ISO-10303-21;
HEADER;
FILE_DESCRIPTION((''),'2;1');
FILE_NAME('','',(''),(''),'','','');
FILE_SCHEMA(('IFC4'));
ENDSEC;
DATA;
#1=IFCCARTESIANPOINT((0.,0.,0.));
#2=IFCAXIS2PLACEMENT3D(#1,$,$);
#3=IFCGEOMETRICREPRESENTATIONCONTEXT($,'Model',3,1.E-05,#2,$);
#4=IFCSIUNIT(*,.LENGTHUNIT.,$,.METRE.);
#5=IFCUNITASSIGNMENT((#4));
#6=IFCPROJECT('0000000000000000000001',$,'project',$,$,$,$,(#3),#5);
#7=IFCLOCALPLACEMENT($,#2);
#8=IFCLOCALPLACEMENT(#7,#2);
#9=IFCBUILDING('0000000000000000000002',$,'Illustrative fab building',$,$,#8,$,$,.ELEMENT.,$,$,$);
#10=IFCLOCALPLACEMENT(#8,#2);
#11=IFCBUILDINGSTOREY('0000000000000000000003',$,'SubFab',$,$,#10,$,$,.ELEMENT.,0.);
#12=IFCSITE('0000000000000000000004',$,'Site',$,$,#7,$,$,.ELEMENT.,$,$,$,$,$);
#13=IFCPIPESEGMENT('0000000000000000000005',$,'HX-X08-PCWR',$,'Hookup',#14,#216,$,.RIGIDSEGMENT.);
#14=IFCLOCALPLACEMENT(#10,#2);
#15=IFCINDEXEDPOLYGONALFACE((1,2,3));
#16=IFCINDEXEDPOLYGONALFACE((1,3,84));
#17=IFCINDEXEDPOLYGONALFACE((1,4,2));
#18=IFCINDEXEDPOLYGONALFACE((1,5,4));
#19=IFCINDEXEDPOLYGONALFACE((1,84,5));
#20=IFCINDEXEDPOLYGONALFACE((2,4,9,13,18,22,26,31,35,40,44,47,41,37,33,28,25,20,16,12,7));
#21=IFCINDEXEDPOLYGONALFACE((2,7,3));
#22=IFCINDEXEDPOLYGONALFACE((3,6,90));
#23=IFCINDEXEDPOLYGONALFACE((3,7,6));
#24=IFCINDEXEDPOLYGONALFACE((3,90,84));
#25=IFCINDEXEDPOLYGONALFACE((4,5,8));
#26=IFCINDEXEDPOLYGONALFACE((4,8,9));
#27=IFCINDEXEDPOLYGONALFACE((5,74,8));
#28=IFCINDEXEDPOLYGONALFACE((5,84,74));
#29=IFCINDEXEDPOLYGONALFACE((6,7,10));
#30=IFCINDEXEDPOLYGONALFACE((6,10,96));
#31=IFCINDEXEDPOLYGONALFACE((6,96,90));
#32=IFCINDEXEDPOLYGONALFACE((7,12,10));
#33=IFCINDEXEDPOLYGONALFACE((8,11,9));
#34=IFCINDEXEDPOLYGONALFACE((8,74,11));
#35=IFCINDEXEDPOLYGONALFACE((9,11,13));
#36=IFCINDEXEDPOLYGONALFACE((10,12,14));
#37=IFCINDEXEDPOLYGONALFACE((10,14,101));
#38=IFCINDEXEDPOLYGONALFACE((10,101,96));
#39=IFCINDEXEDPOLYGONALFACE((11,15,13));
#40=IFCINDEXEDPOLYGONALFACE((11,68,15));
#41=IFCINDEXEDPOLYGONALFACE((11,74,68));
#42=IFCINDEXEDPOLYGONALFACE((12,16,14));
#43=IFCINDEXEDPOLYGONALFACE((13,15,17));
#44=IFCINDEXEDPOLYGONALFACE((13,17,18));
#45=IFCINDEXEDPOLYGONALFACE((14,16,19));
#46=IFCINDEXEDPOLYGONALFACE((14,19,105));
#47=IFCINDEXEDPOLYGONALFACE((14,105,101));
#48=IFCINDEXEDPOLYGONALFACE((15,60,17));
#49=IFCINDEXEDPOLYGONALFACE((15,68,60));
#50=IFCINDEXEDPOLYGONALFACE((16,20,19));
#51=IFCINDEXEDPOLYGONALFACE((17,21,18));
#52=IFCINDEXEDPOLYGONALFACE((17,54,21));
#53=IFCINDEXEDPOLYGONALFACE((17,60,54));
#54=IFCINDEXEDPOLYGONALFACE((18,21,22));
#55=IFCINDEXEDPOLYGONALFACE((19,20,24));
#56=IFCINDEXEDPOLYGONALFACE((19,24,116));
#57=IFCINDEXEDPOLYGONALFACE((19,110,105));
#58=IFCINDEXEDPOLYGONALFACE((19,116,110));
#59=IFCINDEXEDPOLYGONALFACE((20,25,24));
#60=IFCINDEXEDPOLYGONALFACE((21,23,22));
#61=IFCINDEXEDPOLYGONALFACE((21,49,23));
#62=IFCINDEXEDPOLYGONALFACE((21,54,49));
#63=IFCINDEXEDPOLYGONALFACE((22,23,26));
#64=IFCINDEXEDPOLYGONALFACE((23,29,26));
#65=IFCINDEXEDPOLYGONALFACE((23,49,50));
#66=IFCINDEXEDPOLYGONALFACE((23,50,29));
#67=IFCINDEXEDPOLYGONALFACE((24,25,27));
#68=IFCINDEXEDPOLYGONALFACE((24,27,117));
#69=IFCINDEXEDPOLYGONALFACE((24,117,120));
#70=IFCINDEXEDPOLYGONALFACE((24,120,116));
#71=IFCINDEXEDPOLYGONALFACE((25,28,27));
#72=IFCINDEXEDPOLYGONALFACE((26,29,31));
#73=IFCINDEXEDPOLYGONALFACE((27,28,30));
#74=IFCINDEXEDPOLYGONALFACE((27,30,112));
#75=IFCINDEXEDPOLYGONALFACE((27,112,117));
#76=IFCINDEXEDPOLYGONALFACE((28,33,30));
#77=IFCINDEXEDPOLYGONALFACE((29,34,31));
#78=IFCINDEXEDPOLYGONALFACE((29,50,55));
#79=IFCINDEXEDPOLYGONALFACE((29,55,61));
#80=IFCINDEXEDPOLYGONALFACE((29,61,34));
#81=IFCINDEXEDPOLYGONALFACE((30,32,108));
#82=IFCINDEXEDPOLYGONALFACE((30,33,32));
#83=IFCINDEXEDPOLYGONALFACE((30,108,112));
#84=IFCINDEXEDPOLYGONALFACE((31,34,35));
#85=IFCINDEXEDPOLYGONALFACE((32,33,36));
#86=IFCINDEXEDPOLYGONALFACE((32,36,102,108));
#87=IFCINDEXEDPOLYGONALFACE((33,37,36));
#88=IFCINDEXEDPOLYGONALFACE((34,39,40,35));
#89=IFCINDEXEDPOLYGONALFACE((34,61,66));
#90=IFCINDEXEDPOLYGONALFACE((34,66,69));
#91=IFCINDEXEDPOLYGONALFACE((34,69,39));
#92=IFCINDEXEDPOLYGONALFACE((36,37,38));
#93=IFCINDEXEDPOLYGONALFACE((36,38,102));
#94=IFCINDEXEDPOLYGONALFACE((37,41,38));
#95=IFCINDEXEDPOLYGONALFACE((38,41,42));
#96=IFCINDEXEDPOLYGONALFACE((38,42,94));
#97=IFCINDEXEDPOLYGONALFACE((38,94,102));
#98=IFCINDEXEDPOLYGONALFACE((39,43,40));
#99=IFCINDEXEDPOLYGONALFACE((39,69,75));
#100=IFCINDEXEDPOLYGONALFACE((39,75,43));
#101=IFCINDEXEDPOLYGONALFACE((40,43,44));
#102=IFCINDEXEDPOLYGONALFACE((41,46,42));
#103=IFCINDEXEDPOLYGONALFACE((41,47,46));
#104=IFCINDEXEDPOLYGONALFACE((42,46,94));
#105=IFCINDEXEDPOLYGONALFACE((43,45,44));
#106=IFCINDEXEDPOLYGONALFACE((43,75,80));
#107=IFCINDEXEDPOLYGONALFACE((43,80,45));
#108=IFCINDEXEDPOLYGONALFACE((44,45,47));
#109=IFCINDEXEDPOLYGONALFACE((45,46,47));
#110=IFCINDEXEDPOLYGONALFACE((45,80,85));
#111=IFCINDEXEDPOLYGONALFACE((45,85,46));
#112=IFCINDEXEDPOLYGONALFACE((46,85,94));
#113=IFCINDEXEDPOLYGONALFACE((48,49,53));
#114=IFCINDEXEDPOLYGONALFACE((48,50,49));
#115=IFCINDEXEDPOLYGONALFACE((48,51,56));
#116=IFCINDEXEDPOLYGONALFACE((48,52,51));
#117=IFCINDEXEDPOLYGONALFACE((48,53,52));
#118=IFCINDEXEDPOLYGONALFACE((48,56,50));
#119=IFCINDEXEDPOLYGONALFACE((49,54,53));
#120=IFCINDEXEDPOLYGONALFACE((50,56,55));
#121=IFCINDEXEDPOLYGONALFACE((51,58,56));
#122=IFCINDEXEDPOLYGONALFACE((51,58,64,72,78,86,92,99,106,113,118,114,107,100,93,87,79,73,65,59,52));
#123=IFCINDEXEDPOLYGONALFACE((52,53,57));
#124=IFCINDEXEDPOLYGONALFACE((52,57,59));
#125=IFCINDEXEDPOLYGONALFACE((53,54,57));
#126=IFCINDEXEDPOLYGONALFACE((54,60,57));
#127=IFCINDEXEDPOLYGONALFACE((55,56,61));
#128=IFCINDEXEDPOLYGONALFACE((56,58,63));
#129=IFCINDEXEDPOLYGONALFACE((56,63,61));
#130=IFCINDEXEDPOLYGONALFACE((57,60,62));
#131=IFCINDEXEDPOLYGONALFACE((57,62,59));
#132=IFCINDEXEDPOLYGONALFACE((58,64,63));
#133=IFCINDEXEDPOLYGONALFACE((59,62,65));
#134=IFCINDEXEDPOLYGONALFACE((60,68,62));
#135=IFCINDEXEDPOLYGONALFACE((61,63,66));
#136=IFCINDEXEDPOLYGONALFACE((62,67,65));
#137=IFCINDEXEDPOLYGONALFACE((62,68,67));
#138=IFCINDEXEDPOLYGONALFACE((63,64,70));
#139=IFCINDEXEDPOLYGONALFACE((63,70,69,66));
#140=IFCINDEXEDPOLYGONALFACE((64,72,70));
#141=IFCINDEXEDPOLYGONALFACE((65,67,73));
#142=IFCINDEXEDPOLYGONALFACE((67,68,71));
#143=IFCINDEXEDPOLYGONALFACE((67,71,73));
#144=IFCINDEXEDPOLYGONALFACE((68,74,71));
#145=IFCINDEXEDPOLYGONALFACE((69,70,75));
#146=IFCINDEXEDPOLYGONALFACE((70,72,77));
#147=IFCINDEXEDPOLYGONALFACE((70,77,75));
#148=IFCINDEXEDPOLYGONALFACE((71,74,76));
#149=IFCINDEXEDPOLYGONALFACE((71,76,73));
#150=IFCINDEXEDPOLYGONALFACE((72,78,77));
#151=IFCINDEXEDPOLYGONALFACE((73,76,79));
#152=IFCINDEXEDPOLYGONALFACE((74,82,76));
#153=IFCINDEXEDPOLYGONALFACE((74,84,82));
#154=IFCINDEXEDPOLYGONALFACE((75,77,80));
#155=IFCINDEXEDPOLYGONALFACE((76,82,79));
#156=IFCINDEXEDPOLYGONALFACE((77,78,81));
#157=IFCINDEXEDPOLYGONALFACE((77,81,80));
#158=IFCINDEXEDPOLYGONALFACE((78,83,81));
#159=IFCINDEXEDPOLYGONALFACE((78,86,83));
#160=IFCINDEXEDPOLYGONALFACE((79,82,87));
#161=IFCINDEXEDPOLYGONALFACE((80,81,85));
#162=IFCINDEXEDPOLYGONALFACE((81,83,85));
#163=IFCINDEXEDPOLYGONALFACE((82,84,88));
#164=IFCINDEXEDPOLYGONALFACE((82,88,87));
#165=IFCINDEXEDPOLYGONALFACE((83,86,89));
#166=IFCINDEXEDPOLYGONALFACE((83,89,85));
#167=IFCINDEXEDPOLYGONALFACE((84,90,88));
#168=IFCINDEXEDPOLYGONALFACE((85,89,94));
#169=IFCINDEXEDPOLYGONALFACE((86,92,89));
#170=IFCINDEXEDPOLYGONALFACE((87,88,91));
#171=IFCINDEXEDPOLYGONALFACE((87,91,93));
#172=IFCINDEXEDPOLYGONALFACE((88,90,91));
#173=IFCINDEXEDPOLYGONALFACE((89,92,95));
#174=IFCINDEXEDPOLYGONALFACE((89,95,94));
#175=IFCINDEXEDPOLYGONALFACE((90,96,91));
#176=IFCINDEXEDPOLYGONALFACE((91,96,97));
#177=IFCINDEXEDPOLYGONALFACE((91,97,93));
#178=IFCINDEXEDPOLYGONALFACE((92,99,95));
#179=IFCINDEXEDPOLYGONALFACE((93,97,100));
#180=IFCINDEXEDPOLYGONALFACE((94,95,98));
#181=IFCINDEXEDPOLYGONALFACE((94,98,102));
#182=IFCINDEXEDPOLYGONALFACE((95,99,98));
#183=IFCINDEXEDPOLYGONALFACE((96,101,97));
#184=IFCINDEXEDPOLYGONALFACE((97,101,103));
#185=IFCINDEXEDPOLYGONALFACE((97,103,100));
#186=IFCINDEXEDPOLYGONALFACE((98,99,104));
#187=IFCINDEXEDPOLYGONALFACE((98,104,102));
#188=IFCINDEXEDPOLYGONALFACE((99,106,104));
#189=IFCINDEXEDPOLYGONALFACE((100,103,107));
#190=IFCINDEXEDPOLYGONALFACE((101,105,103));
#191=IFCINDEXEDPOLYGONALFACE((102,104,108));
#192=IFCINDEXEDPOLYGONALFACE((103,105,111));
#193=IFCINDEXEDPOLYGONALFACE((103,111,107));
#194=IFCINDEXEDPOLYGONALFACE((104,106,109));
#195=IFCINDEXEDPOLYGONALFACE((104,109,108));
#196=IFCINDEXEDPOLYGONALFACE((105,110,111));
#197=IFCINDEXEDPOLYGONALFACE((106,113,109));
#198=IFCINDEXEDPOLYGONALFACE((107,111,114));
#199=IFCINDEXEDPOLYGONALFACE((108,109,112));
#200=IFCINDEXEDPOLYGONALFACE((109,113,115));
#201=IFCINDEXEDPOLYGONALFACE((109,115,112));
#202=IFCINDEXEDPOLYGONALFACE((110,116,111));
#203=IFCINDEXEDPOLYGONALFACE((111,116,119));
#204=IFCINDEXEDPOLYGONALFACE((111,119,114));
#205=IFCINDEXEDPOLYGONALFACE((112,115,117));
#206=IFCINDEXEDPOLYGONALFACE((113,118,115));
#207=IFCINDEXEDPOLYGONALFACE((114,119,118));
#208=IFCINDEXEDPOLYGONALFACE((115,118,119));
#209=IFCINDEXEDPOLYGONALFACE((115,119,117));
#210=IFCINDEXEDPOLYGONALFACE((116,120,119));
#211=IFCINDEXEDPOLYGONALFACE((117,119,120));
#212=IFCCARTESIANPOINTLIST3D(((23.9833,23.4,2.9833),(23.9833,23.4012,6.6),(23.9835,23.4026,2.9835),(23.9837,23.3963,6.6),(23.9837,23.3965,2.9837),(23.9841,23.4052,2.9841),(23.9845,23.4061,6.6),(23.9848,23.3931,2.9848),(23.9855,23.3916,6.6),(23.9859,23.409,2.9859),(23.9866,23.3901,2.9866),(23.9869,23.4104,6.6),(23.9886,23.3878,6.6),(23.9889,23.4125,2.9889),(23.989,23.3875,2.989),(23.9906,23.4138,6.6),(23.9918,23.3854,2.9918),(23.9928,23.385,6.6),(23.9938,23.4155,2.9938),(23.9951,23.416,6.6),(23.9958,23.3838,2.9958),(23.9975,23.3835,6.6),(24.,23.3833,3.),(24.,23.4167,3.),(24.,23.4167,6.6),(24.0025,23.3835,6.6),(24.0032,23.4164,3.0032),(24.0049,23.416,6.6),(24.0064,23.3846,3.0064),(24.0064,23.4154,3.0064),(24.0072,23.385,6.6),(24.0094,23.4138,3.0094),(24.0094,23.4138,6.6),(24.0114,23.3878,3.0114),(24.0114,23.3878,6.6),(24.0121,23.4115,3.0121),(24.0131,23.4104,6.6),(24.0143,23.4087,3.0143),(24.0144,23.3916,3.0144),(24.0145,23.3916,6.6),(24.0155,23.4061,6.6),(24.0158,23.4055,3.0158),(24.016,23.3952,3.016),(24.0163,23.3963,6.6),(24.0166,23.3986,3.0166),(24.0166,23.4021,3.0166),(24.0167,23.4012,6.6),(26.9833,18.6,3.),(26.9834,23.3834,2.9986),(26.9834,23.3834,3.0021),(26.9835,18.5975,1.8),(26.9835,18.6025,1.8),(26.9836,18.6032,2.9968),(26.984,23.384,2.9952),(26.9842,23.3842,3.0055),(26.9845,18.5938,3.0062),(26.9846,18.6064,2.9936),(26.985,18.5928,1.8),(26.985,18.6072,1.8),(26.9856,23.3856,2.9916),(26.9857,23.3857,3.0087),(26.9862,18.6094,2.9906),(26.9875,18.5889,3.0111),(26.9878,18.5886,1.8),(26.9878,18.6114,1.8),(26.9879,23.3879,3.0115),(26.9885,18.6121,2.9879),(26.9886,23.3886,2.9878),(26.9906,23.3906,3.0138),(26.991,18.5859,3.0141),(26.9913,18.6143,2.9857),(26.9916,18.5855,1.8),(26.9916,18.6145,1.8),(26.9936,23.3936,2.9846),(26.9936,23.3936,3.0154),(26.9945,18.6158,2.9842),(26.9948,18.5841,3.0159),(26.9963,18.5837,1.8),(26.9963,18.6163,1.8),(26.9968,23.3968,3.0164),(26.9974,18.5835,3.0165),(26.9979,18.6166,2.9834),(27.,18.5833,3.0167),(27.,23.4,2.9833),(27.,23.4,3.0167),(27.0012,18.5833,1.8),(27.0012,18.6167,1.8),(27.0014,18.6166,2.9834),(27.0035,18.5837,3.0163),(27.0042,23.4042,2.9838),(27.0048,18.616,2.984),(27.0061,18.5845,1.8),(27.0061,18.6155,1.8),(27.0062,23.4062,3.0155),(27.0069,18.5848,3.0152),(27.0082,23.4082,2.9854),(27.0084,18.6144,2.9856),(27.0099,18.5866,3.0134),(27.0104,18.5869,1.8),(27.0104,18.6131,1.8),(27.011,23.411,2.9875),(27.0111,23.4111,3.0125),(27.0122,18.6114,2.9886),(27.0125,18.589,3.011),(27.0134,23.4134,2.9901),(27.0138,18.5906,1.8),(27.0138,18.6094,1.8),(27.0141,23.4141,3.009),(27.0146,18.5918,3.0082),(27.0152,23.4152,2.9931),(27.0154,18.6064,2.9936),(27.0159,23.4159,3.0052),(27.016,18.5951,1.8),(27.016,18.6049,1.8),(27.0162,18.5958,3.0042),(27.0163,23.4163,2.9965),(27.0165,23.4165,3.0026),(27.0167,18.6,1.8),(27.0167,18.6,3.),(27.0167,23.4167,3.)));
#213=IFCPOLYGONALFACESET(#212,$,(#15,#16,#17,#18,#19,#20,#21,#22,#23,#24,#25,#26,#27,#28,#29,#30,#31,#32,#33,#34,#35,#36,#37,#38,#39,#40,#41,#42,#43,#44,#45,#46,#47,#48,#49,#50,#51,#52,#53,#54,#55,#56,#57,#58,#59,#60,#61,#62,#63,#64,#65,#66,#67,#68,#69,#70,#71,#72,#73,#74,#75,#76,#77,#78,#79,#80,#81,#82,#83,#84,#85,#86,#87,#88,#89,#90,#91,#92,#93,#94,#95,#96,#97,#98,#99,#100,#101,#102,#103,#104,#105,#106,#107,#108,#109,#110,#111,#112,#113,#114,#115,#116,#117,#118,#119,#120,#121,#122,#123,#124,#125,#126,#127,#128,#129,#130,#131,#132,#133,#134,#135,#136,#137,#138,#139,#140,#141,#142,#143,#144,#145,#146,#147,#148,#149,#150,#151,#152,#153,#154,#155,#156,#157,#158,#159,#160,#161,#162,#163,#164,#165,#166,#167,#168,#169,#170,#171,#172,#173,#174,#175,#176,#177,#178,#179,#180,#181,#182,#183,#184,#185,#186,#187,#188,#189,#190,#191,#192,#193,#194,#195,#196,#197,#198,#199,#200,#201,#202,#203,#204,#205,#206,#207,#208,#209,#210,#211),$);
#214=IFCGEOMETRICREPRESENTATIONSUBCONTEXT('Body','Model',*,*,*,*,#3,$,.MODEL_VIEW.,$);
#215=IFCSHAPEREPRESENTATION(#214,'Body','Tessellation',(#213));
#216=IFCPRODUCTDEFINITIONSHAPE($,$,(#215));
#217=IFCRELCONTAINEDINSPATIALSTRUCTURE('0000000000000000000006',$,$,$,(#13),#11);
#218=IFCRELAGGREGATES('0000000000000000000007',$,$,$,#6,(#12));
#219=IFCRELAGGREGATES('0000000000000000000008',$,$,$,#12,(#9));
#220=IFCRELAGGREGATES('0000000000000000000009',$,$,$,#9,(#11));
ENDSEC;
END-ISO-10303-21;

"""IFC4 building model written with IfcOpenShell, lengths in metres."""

from ifc_helpers import new_model, entity, si_unit, origin, place, context, subcontext, project, spatial, element, save


model = new_model("IFC4")

# Units and contexts
model_context = context("Model", 3, precision=1e-05, world=origin())
body_context = subcontext(model_context, "Body", "Model", "MODEL_VIEW")
ifc_project = project(units=[si_unit("LENGTHUNIT", "METRE")], contexts=[model_context])

# Site, building, storey
site_placement = place(None, origin())
site = spatial("IfcSite", under=ifc_project, at=site_placement, Name="Site", CompositionType="ELEMENT")
building_placement = place(site_placement, origin())
building = spatial("IfcBuilding", under=site, at=building_placement, Name="Illustrative fab building", CompositionType="ELEMENT")
storey_placement = place(building_placement, origin())
storey = spatial("IfcBuildingStorey", under=building, at=storey_placement, Name="SubFab", CompositionType="ELEMENT", Elevation=0.0)

# Pipe segment
pipe_segment_1_placement = place(storey_placement, origin())
element("IfcPipeSegment", 1, at=pipe_segment_1_placement, inside=storey, Name="HX-X08-PCWR", ObjectType="Hookup", PredefinedType="RIGIDSEGMENT", context=body_context, shape_type="AdvancedSweptSolid", body=[
    entity("IfcSweptDiskSolid", entity("IfcPolyline", [entity("IfcCartesianPoint", [27.0, 18.6, 1.8]), entity("IfcCartesianPoint", [27.0, 18.6, 3.0]), entity("IfcCartesianPoint", [27.0, 23.4, 3.0]), entity("IfcCartesianPoint", [24.0, 23.4, 3.0]), entity("IfcCartesianPoint", [24.0, 23.4, 6.6])]), 0.0167),
])

save(model, "model.ifc")
